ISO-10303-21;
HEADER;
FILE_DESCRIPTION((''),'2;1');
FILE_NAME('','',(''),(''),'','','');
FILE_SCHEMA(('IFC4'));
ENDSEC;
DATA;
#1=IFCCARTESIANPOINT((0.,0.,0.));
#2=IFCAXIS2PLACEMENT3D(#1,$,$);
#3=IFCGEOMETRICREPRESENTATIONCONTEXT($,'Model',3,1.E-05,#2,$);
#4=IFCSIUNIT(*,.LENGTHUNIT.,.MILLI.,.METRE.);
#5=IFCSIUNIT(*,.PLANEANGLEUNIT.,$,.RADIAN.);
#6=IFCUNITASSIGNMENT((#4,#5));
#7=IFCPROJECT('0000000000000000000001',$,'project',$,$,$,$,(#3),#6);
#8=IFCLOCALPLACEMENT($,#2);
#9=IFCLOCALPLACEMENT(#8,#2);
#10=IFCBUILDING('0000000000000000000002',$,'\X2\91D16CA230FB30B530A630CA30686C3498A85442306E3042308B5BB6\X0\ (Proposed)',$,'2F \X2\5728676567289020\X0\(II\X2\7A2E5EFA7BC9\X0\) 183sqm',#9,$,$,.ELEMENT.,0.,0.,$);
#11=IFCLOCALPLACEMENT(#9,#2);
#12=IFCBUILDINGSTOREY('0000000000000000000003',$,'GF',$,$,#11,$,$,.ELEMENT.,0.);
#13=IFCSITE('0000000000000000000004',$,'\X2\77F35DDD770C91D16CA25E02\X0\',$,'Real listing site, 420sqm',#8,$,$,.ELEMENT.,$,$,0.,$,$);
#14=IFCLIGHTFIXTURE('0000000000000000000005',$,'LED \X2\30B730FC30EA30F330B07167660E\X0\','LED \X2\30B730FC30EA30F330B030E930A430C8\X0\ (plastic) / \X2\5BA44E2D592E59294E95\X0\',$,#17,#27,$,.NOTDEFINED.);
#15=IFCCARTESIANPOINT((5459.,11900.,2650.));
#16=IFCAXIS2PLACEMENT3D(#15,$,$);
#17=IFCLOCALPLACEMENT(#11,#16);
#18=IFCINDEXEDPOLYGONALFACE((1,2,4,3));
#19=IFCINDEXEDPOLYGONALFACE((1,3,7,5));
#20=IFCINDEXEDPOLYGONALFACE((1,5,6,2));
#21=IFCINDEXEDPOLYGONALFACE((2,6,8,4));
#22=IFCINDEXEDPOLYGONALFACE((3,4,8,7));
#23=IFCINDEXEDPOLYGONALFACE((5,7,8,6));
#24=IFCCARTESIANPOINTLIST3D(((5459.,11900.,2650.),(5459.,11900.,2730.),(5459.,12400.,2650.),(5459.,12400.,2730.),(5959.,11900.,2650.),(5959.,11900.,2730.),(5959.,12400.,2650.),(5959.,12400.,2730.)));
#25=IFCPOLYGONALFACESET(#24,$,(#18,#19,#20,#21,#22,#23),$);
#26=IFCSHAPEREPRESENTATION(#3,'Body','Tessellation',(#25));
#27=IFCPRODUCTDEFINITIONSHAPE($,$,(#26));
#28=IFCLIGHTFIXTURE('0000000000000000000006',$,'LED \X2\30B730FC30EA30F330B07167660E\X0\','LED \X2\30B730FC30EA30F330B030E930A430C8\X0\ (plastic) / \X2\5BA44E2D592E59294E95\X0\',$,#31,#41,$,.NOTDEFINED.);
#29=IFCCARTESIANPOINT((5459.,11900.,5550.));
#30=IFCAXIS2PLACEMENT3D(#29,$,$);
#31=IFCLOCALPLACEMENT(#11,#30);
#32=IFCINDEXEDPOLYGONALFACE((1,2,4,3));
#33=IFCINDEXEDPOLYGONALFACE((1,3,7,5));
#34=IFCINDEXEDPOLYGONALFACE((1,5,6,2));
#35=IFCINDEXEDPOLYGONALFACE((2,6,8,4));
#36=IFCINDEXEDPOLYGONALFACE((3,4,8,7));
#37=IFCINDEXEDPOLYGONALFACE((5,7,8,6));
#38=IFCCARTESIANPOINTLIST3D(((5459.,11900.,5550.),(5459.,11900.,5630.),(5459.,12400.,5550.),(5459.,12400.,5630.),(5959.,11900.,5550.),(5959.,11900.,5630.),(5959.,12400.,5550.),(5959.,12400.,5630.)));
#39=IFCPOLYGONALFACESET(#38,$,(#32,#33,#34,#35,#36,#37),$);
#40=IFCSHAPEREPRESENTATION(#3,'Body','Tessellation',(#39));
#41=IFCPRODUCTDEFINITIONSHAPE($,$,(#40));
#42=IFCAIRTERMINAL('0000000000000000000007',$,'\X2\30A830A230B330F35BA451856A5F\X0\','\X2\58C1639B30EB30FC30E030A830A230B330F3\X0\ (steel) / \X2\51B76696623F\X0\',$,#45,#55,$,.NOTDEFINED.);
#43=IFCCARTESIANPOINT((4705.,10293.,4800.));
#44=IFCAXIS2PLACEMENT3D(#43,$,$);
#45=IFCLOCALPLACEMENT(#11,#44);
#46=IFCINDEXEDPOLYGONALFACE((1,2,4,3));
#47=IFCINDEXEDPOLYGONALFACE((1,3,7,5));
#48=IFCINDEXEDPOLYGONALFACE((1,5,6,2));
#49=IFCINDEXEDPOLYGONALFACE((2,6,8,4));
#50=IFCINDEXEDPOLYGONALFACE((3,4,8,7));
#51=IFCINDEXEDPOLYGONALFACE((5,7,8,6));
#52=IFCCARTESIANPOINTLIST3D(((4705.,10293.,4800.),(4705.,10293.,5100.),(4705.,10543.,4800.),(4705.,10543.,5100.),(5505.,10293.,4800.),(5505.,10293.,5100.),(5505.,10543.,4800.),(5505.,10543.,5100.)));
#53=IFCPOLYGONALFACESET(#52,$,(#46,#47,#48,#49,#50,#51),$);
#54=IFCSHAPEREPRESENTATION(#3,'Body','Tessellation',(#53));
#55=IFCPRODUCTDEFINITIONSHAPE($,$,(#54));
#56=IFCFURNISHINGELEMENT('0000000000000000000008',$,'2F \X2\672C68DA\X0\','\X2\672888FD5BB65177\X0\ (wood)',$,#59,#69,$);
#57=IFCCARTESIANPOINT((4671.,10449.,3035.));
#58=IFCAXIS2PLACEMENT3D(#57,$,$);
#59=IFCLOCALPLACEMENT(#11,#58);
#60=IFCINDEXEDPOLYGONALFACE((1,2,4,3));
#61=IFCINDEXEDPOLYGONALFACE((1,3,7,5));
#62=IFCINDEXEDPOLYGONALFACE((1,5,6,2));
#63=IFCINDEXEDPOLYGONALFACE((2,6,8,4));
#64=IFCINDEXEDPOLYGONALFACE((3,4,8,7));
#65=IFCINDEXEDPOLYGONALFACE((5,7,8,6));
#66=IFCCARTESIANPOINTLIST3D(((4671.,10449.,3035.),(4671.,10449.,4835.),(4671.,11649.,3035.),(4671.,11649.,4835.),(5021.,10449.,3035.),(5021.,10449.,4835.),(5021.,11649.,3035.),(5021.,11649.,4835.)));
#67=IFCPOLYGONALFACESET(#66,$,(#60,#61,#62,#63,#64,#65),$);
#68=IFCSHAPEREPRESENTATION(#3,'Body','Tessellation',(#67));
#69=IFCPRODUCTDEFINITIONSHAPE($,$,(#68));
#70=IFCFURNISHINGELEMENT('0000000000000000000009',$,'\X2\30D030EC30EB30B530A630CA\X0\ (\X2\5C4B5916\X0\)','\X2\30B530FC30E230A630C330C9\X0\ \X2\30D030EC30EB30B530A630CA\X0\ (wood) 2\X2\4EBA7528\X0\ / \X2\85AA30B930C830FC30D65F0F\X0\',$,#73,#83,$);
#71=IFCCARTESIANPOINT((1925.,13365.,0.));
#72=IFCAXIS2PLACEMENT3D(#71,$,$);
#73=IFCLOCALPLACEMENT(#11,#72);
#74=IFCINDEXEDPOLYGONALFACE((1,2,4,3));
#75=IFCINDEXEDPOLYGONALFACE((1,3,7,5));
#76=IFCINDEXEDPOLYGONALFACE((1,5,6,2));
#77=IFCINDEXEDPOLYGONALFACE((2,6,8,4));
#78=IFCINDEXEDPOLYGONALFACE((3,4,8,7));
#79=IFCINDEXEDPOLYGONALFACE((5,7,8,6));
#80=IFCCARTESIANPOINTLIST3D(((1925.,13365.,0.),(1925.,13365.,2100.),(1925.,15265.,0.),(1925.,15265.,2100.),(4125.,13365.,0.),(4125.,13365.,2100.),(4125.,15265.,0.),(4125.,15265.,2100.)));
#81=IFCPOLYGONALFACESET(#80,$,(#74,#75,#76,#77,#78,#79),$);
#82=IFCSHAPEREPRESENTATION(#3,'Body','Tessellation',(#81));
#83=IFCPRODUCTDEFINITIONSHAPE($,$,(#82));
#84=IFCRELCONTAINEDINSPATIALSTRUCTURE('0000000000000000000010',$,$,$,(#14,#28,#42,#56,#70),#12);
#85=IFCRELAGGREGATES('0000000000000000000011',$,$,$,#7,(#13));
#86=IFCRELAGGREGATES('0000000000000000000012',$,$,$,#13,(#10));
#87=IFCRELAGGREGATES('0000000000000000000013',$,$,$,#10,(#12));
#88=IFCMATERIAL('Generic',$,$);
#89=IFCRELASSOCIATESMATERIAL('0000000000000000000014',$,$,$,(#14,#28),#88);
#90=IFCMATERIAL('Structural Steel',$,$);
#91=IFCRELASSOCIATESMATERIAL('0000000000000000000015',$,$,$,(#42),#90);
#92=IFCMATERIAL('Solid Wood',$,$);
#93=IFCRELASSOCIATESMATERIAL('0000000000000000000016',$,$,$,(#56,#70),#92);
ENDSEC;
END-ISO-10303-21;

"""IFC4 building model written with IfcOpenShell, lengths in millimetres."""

from ifc_helpers import new_model, si_unit, frame, frame_2d, origin, place, context, project, spatial, rectangle, extrude, material, element, save


model = new_model("IFC4")

# Units and contexts
model_context = context("Model", 3, precision=1e-05, world=origin())
ifc_project = project(units=[si_unit("LENGTHUNIT", "METRE", prefix="MILLI"), si_unit("PLANEANGLEUNIT", "RADIAN")], contexts=[model_context])

# Site, building, storey
site_placement = place(None, origin())
site = spatial("IfcSite", under=ifc_project, at=site_placement, Name="石川県金沢市", ObjectType="Real listing site, 420sqm", CompositionType="ELEMENT", RefElevation=0.0)
building_placement = place(site_placement, origin())
building = spatial("IfcBuilding", under=site, at=building_placement, Name="金沢・サウナと水風呂のある家 (Proposed)", ObjectType="2F 在来木造(II種建築) 183sqm", CompositionType="ELEMENT", ElevationOfRefHeight=0.0, ElevationOfTerrain=0.0)
storey_placement = place(building_placement, origin())
storey = spatial("IfcBuildingStorey", under=building, at=storey_placement, Name="GF", CompositionType="ELEMENT", Elevation=0.0)

# Shared definitions
ifc_material_1 = material(Name="Solid Wood")

# Shared definitions
ifc_material_2 = material(Name="Structural Steel")

# Shared definitions
ifc_material_3 = material(Name="Generic")

# Light fixtures
light_fixture_1_placement = place(storey_placement, frame((5459.0, 11900.0, 2650.0)))
element("IfcLightFixture", 1, at=light_fixture_1_placement, inside=storey, material=ifc_material_3, Name="LED シーリング照明", Description="LED シーリングライト (plastic) / 室中央天井", PredefinedType="NOTDEFINED", context=model_context, shape_type="SweptSolid", body=[
    extrude(rectangle(XDim=500.0, YDim=500.0, at=frame_2d((250.0, 250.0))), frame((5459.0, 11900.0, 2650.0)), (0.0, 0.0, 1.0), 80.0),
])
light_fixture_2_placement = place(storey_placement, frame((5459.0, 11900.0, 5550.0)))
element("IfcLightFixture", 2, at=light_fixture_2_placement, inside=storey, material=ifc_material_3, Name="LED シーリング照明", Description="LED シーリングライト (plastic) / 室中央天井", PredefinedType="NOTDEFINED", context=model_context, shape_type="SweptSolid", body=[
    extrude(rectangle(XDim=500.0, YDim=500.0, at=frame_2d((250.0, 250.0))), frame((5459.0, 11900.0, 5550.0)), (0.0, 0.0, 1.0), 80.0),
])

# Air terminal
air_terminal_placement = place(storey_placement, frame((4705.0, 10293.0, 4800.0)))
element("IfcAirTerminal", 3, at=air_terminal_placement, inside=storey, material=ifc_material_2, Name="エアコン室内機", Description="壁掛ルームエアコン (steel) / 冷暖房", PredefinedType="NOTDEFINED", context=model_context, shape_type="SweptSolid", body=[
    extrude(rectangle(XDim=800.0, YDim=250.0, at=frame_2d((400.0, 125.0))), frame((4705.0, 10293.0, 4800.0)), (0.0, 0.0, 1.0), 300.0),
])

# Furnishing elements
furnishing_1_placement = place(storey_placement, frame((4671.0, 10449.0, 3035.0)))
element("IfcFurnishingElement", 4, at=furnishing_1_placement, inside=storey, material=ifc_material_1, Name="2F 本棚", Description="木製家具 (wood)", context=model_context, shape_type="SweptSolid", body=[
    extrude(rectangle(XDim=350.0, YDim=1200.0, at=frame_2d((175.0, 600.0))), frame((4671.0, 10449.0, 3035.0)), (0.0, 0.0, 1.0), 1800.0),
])
furnishing_2_placement = place(storey_placement, frame((1925.0, 13365.0, 0.0)))
element("IfcFurnishingElement", 5, at=furnishing_2_placement, inside=storey, material=ifc_material_1, Name="バレルサウナ (屋外)", Description="サーモウッド バレルサウナ (wood) 2人用 / 薪ストーブ式", context=model_context, shape_type="SweptSolid", body=[
    extrude(rectangle(XDim=2200.0, YDim=1900.0, at=frame_2d((1100.0, 950.0))), frame((1925.0, 13365.0, 0.0)), (0.0, 0.0, 1.0), 2100.0),
])

save(model, "model.ifc")
